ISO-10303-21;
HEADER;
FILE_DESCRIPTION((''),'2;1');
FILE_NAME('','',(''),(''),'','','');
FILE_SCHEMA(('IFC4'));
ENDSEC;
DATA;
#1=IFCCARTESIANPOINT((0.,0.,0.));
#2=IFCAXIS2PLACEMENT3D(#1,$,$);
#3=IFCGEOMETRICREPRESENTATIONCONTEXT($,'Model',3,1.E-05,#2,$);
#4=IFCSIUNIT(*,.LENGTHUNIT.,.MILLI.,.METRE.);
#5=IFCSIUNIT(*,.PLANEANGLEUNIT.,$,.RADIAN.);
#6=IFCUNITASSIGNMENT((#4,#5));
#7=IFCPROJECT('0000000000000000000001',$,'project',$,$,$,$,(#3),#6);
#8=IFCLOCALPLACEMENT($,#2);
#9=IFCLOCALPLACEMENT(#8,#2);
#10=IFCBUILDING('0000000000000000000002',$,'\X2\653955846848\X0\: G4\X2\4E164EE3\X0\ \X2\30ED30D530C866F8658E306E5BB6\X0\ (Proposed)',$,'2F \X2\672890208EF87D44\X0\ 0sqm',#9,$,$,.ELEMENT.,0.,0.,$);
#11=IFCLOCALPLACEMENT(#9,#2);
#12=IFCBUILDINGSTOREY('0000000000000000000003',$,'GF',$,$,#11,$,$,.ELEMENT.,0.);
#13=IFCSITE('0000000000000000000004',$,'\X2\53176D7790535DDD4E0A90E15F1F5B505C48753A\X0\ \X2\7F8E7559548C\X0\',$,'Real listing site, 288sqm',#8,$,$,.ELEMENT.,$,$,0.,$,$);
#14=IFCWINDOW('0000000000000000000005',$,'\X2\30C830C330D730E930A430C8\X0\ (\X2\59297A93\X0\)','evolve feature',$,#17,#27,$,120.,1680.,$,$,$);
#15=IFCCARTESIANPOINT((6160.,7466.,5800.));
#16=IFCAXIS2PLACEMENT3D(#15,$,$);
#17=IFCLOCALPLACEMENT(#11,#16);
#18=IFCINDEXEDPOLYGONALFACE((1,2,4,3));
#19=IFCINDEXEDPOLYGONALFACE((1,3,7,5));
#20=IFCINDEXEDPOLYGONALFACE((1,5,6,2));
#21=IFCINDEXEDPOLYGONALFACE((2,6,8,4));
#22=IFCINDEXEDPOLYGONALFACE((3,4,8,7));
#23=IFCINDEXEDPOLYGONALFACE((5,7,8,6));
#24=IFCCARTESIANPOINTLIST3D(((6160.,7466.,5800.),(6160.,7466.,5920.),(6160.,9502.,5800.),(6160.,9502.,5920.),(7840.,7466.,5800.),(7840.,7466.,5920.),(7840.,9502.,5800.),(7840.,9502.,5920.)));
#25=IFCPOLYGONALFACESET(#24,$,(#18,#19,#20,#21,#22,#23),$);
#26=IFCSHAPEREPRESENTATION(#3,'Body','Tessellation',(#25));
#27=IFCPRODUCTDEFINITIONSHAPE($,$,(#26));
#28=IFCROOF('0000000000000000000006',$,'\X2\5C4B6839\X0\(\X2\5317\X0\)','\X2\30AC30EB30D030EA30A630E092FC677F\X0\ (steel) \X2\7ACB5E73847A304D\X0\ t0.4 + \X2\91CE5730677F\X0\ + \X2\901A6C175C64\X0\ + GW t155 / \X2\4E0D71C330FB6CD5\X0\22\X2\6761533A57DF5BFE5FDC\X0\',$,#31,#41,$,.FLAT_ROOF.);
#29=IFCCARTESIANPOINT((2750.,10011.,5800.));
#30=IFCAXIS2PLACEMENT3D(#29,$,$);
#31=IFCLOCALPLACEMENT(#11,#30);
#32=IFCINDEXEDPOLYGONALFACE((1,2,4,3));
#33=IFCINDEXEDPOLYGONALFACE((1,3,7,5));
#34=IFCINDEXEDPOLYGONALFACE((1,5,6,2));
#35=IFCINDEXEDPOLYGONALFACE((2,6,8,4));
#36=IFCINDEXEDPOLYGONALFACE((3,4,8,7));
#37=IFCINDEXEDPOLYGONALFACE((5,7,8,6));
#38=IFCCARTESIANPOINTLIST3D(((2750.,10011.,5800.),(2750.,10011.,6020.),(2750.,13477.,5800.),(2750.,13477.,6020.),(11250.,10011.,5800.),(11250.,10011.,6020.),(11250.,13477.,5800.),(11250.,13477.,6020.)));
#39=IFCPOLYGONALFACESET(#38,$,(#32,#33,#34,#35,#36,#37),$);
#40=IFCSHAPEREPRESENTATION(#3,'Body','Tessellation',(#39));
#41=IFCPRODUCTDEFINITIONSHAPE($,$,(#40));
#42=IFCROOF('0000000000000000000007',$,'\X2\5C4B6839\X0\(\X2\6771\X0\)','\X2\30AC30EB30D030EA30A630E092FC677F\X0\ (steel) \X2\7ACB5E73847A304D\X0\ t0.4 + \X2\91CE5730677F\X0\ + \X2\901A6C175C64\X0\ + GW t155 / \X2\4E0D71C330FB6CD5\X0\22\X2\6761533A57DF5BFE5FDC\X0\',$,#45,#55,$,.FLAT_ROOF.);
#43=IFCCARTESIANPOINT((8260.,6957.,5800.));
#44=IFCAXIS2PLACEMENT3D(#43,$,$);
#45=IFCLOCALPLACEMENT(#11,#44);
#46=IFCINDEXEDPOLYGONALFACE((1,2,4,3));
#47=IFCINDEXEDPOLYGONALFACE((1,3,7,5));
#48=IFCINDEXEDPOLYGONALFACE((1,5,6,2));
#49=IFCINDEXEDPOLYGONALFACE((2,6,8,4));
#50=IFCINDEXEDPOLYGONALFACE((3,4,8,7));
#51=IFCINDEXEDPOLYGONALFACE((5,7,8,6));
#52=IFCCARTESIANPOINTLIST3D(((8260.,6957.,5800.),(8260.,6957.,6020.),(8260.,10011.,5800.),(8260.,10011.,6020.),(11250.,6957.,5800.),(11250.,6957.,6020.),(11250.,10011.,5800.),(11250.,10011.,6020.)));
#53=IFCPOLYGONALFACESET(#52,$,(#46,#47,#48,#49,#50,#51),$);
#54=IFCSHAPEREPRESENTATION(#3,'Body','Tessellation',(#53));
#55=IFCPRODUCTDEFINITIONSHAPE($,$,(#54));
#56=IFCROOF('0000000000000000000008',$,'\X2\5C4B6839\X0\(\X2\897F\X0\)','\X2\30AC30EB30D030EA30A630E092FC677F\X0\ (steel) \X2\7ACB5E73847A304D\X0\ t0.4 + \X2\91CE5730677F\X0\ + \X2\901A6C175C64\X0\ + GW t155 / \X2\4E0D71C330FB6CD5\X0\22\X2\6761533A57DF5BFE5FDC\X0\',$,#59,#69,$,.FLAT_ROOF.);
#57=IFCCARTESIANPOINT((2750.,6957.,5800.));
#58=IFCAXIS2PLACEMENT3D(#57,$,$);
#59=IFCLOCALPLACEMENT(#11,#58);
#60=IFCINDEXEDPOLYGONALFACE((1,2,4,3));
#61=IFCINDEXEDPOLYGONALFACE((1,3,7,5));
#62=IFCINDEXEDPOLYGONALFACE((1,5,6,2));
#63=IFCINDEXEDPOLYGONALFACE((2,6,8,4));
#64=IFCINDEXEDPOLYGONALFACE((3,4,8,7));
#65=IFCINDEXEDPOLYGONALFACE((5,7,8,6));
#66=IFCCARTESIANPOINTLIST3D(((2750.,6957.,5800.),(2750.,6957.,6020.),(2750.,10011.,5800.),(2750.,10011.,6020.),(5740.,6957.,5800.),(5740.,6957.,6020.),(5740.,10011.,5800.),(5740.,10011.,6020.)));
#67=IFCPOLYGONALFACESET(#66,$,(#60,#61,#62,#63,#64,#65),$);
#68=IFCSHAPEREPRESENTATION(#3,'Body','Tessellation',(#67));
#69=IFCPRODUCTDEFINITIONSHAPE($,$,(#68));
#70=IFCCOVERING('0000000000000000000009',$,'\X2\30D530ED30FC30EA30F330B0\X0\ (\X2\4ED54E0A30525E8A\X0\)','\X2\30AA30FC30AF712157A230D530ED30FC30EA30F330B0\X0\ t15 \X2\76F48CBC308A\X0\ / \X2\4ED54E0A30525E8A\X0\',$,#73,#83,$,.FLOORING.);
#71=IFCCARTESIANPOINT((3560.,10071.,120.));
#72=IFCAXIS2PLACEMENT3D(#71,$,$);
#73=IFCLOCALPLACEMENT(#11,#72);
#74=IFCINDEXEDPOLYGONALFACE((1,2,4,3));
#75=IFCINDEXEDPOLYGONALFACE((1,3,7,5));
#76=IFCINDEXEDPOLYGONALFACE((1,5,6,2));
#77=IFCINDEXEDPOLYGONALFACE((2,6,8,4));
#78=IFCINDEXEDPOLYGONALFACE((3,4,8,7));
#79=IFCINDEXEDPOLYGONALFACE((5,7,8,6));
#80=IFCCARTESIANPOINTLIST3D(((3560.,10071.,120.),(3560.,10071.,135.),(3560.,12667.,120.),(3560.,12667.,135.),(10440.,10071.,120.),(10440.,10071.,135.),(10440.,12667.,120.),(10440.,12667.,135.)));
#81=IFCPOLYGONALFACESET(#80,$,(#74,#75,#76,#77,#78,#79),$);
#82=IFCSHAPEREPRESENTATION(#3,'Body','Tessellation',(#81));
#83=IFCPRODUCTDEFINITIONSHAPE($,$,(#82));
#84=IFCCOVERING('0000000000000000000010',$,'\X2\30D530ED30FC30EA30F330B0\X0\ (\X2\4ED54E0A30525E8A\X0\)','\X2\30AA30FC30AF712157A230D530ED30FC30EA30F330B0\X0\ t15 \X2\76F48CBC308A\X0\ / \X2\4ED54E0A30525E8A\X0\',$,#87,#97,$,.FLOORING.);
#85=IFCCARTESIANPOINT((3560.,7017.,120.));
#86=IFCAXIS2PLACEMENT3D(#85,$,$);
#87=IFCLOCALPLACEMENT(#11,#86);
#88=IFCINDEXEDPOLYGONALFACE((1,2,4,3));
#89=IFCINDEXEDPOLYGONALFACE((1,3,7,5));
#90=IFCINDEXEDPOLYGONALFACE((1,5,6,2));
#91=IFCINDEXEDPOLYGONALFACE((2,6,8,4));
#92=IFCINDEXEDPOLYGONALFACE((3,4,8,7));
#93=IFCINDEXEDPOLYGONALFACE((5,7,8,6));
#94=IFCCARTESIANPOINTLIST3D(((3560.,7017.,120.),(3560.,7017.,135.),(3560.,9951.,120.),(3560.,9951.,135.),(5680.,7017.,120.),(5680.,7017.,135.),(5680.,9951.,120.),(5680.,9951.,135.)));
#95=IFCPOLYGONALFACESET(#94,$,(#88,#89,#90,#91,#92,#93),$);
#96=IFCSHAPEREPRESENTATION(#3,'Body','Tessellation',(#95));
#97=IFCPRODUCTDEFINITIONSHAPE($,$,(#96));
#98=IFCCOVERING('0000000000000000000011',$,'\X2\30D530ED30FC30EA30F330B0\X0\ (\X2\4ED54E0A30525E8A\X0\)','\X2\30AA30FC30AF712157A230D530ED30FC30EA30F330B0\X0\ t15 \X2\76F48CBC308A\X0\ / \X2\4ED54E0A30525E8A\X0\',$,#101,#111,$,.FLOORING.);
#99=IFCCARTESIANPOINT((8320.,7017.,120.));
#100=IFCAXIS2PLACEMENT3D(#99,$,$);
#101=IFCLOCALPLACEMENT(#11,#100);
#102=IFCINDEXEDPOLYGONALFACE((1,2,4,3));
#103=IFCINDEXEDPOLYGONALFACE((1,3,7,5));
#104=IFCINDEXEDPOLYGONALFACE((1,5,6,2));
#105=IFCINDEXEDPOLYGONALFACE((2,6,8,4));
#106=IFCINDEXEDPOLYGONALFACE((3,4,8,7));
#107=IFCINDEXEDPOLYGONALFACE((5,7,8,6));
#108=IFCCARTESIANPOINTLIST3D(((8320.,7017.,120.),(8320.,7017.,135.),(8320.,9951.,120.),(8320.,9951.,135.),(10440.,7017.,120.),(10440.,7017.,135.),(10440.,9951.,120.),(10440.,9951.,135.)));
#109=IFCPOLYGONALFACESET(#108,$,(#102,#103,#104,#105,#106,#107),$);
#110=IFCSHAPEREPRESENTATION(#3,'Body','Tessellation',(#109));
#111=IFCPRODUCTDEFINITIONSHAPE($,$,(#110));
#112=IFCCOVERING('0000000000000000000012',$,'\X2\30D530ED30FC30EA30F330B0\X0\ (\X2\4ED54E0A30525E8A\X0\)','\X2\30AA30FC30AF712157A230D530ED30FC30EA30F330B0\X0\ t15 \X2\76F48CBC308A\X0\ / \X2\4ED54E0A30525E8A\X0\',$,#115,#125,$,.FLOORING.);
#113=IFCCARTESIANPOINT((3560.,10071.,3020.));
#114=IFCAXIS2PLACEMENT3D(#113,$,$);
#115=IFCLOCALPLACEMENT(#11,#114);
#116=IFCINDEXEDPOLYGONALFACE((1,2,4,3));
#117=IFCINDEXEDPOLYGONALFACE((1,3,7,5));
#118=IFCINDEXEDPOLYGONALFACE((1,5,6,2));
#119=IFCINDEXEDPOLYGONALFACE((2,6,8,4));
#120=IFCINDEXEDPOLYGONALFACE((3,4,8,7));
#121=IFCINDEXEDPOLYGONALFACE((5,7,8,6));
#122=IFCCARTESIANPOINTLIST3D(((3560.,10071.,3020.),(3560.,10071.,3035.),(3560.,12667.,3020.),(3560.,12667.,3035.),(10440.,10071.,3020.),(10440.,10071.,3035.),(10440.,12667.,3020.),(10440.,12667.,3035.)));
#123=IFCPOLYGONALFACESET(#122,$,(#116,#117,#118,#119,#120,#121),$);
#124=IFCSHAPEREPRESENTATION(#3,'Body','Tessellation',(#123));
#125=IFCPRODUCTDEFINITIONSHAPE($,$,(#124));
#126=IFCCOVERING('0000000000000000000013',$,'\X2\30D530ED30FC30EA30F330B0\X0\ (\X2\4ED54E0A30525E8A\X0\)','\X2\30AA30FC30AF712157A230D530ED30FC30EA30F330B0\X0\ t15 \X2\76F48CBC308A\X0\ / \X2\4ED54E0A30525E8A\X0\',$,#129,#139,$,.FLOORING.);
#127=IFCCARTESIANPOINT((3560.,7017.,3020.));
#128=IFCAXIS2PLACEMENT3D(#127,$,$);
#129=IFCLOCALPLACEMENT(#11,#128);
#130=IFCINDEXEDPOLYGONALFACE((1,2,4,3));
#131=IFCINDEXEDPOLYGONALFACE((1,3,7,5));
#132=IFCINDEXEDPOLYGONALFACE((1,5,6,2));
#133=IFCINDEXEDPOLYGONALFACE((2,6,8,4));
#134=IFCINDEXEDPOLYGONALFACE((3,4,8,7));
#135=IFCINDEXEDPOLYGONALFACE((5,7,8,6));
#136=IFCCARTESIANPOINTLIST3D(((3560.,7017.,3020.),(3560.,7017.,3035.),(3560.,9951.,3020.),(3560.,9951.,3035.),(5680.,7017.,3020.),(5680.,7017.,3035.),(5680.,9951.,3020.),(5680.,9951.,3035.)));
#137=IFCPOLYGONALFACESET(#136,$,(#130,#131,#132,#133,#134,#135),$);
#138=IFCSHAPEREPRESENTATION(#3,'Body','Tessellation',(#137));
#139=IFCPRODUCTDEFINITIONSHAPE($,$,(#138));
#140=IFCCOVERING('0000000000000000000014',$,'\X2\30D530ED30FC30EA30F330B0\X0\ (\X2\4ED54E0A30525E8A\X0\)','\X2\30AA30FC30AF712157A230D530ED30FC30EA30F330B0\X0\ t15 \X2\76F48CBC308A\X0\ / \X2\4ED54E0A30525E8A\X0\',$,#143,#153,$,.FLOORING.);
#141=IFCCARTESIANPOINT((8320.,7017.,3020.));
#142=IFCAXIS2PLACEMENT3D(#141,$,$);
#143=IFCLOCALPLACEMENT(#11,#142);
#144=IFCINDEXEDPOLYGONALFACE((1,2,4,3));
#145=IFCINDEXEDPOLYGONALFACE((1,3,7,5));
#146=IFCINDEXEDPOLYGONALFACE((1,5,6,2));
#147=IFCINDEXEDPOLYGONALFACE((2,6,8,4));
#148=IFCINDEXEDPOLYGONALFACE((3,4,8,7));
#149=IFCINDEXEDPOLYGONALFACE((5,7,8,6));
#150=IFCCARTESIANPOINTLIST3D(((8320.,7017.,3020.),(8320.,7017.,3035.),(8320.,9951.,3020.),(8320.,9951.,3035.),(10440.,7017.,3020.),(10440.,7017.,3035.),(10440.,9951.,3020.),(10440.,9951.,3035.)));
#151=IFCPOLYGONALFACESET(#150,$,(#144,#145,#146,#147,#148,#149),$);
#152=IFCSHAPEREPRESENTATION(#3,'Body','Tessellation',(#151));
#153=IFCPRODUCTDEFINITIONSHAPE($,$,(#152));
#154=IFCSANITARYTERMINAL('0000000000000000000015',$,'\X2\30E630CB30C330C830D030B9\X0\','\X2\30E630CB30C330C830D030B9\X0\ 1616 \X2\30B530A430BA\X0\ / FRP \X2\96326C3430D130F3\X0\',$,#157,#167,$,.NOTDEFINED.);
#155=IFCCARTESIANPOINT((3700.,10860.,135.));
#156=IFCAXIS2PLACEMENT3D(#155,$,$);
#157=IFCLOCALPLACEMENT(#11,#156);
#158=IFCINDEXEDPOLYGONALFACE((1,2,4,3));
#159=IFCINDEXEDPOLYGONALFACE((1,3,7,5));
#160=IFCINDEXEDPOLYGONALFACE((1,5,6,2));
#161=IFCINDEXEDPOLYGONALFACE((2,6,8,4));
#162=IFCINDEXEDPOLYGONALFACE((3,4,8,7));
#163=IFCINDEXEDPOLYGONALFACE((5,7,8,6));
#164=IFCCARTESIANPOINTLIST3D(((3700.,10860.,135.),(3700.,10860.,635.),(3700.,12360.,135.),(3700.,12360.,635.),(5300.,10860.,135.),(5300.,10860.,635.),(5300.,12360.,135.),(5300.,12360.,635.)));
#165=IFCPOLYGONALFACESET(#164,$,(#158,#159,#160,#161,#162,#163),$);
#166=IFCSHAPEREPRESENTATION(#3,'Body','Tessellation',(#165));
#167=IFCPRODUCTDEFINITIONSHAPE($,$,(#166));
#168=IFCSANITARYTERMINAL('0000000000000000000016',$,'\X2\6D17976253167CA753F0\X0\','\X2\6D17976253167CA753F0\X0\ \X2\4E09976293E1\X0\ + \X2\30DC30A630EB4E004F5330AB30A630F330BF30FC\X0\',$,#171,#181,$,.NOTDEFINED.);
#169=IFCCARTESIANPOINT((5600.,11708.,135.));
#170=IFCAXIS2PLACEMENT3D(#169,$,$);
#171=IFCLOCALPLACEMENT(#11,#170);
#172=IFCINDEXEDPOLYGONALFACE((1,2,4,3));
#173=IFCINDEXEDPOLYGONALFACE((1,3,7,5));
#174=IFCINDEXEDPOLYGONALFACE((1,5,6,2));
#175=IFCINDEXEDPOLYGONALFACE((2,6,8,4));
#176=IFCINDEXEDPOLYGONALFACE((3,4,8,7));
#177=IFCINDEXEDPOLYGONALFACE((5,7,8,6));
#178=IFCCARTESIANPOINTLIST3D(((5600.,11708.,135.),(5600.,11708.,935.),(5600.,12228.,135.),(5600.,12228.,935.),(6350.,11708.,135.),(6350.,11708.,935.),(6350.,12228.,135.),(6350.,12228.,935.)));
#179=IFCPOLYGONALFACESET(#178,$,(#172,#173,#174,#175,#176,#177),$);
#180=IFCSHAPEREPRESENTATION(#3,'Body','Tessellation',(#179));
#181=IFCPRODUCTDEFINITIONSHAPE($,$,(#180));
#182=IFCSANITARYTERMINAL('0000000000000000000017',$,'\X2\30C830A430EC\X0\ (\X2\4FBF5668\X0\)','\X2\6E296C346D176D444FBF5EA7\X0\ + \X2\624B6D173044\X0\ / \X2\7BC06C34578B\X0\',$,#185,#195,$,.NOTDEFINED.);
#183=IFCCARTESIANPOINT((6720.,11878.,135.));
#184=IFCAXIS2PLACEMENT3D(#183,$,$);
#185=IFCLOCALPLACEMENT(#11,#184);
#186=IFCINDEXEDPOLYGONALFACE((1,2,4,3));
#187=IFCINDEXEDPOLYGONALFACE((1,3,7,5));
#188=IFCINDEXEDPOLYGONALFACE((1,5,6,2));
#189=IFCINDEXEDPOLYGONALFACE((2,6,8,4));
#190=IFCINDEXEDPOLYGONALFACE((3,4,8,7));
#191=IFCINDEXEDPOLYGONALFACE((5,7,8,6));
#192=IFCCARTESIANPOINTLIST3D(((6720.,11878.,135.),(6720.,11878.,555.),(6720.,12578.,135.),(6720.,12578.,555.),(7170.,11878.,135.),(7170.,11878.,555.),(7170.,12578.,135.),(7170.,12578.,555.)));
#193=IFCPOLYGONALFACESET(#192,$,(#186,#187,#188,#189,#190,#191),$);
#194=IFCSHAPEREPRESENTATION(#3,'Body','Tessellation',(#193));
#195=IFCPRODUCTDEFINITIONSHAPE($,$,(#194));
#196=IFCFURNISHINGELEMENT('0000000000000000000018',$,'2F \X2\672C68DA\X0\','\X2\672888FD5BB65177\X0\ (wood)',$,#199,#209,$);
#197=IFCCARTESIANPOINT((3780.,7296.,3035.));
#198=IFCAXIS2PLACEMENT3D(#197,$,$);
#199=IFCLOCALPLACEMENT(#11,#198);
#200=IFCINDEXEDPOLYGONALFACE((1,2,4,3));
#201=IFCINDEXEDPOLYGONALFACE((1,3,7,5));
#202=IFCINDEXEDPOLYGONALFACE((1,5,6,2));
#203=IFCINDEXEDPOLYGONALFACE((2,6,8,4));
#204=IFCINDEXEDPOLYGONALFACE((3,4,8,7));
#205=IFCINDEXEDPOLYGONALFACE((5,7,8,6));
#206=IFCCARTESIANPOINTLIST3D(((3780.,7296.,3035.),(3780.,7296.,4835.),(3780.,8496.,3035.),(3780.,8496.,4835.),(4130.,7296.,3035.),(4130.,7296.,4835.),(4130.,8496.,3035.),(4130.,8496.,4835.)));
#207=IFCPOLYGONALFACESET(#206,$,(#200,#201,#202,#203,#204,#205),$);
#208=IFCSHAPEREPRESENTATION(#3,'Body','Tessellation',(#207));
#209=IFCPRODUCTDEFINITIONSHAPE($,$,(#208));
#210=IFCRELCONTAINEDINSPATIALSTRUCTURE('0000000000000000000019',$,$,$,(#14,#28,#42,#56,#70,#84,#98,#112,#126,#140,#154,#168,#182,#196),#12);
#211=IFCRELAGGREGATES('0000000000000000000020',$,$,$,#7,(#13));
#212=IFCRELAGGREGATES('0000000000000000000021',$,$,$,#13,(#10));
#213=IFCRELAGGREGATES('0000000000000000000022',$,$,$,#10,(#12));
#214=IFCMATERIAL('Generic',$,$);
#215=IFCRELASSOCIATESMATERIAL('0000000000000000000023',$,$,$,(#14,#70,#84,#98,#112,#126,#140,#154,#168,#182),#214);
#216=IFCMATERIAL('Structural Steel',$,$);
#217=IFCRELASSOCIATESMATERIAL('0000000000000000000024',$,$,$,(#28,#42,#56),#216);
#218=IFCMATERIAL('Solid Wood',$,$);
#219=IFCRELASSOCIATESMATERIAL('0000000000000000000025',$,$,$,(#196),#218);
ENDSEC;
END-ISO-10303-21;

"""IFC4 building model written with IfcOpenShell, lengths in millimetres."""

from ifc_helpers import new_model, si_unit, frame, frame_2d, origin, place, context, project, spatial, rectangle, extrude, material, element, save


model = new_model("IFC4")

# Units and contexts
model_context = context("Model", 3, precision=1e-05, world=origin())
ifc_project = project(units=[si_unit("LENGTHUNIT", "METRE", prefix="MILLI"), si_unit("PLANEANGLEUNIT", "RADIAN")], contexts=[model_context])

# Site, building, storey
site_placement = place(None, origin())
site = spatial("IfcSite", under=ifc_project, at=site_placement, Name="北海道川上郡弟子屈町 美留和", ObjectType="Real listing site, 288sqm", CompositionType="ELEMENT", RefElevation=0.0)
building_placement = place(site_placement, origin())
building = spatial("IfcBuilding", under=site, at=building_placement, Name="改善案: G4世代 ロフト書斎の家 (Proposed)", ObjectType="2F 木造軸組 0sqm", CompositionType="ELEMENT", ElevationOfRefHeight=0.0, ElevationOfTerrain=0.0)
storey_placement = place(building_placement, origin())
storey = spatial("IfcBuildingStorey", under=building, at=storey_placement, Name="GF", CompositionType="ELEMENT", Elevation=0.0)

# Shared definitions
ifc_material_1 = material(Name="Solid Wood")

# Window
ifc_material_2 = material(Name="Generic")
window_1_placement = place(storey_placement, frame((6160.0, 7466.0, 5800.0)))
element("IfcWindow", 1, at=window_1_placement, inside=storey, material=ifc_material_2, Name="トップライト (天窓)", Description="evolve feature", OverallHeight=120.0, OverallWidth=1680.0, context=model_context, shape_type="SweptSolid", body=[
    extrude(rectangle(XDim=1680.0, YDim=2036.0, at=frame_2d((840.0, 1018.0))), frame((6160.0, 7466.0, 5800.0)), (0.0, 0.0, 1.0), 120.0),
])

# Roofs
ifc_material_3 = material(Name="Structural Steel")
roof_1_placement = place(storey_placement, frame((2750.0, 10011.0, 5800.0)))
element("IfcRoof", 2, at=roof_1_placement, inside=storey, material=ifc_material_3, Name="屋根(北)", Description="ガルバリウム鋼板 (steel) 立平葺き t0.4 + 野地板 + 通気層 + GW t155 / 不燃・法22条区域対応", PredefinedType="FLAT_ROOF", context=model_context, shape_type="SweptSolid", body=[
    extrude(rectangle(XDim=8500.0, YDim=3466.0, at=frame_2d((4250.0, 1733.0))), frame((2750.0, 10011.0, 5800.0)), (0.0, 0.0, 1.0), 220.0),
])
roof_2_placement = place(storey_placement, frame((8260.0, 6957.0, 5800.0)))
element("IfcRoof", 3, at=roof_2_placement, inside=storey, material=ifc_material_3, Name="屋根(東)", Description="ガルバリウム鋼板 (steel) 立平葺き t0.4 + 野地板 + 通気層 + GW t155 / 不燃・法22条区域対応", PredefinedType="FLAT_ROOF", context=model_context, shape_type="SweptSolid", body=[
    extrude(rectangle(XDim=2990.0, YDim=3054.0, at=frame_2d((1495.0, 1527.0))), frame((8260.0, 6957.0, 5800.0)), (0.0, 0.0, 1.0), 220.0),
])
roof_3_placement = place(storey_placement, frame((2750.0, 6957.0, 5800.0)))
element("IfcRoof", 4, at=roof_3_placement, inside=storey, material=ifc_material_3, Name="屋根(西)", Description="ガルバリウム鋼板 (steel) 立平葺き t0.4 + 野地板 + 通気層 + GW t155 / 不燃・法22条区域対応", PredefinedType="FLAT_ROOF", context=model_context, shape_type="SweptSolid", body=[
    extrude(rectangle(XDim=2990.0, YDim=3054.0, at=frame_2d((1495.0, 1527.0))), frame((2750.0, 6957.0, 5800.0)), (0.0, 0.0, 1.0), 220.0),
])

# Coverings
covering_1_placement = place(storey_placement, frame((3560.0, 10071.0, 120.0)))
element("IfcCovering", 5, at=covering_1_placement, inside=storey, material=ifc_material_2, Name="フローリング (仕上げ床)", Description="オーク無垢フローリング t15 直貼り / 仕上げ床", PredefinedType="FLOORING", context=model_context, shape_type="SweptSolid", body=[
    extrude(rectangle(XDim=6880.0, YDim=2596.0, at=frame_2d((3440.0, 1298.0))), frame((3560.0, 10071.0, 120.0)), (0.0, 0.0, 1.0), 15.0),
])
covering_2_placement = place(storey_placement, frame((3560.0, 7017.0, 120.0)))
element("IfcCovering", 6, at=covering_2_placement, inside=storey, material=ifc_material_2, Name="フローリング (仕上げ床)", Description="オーク無垢フローリング t15 直貼り / 仕上げ床", PredefinedType="FLOORING", context=model_context, shape_type="SweptSolid", body=[
    extrude(rectangle(XDim=2120.0, YDim=2934.0, at=frame_2d((1060.0, 1467.0))), frame((3560.0, 7017.0, 120.0)), (0.0, 0.0, 1.0), 15.0),
])
covering_3_placement = place(storey_placement, frame((8320.0, 7017.0, 120.0)))
element("IfcCovering", 7, at=covering_3_placement, inside=storey, material=ifc_material_2, Name="フローリング (仕上げ床)", Description="オーク無垢フローリング t15 直貼り / 仕上げ床", PredefinedType="FLOORING", context=model_context, shape_type="SweptSolid", body=[
    extrude(rectangle(XDim=2120.0, YDim=2934.0, at=frame_2d((1060.0, 1467.0))), frame((8320.0, 7017.0, 120.0)), (0.0, 0.0, 1.0), 15.0),
])
covering_4_placement = place(storey_placement, frame((3560.0, 10071.0, 3020.0)))
element("IfcCovering", 8, at=covering_4_placement, inside=storey, material=ifc_material_2, Name="フローリング (仕上げ床)", Description="オーク無垢フローリング t15 直貼り / 仕上げ床", PredefinedType="FLOORING", context=model_context, shape_type="SweptSolid", body=[
    extrude(rectangle(XDim=6880.0, YDim=2596.0, at=frame_2d((3440.0, 1298.0))), frame((3560.0, 10071.0, 3020.0)), (0.0, 0.0, 1.0), 15.0),
])
covering_5_placement = place(storey_placement, frame((3560.0, 7017.0, 3020.0)))
element("IfcCovering", 9, at=covering_5_placement, inside=storey, material=ifc_material_2, Name="フローリング (仕上げ床)", Description="オーク無垢フローリング t15 直貼り / 仕上げ床", PredefinedType="FLOORING", context=model_context, shape_type="SweptSolid", body=[
    extrude(rectangle(XDim=2120.0, YDim=2934.0, at=frame_2d((1060.0, 1467.0))), frame((3560.0, 7017.0, 3020.0)), (0.0, 0.0, 1.0), 15.0),
])
covering_6_placement = place(storey_placement, frame((8320.0, 7017.0, 3020.0)))
element("IfcCovering", 10, at=covering_6_placement, inside=storey, material=ifc_material_2, Name="フローリング (仕上げ床)", Description="オーク無垢フローリング t15 直貼り / 仕上げ床", PredefinedType="FLOORING", context=model_context, shape_type="SweptSolid", body=[
    extrude(rectangle(XDim=2120.0, YDim=2934.0, at=frame_2d((1060.0, 1467.0))), frame((8320.0, 7017.0, 3020.0)), (0.0, 0.0, 1.0), 15.0),
])

# Sanitary terminals
sanitary_terminal_1_placement = place(storey_placement, frame((3700.0, 10860.0, 135.0)))
element("IfcSanitaryTerminal", 11, at=sanitary_terminal_1_placement, inside=storey, material=ifc_material_2, Name="ユニットバス", Description="ユニットバス 1616 サイズ / FRP 防水パン", PredefinedType="NOTDEFINED", context=model_context, shape_type="SweptSolid", body=[
    extrude(rectangle(XDim=1600.0, YDim=1500.0, at=frame_2d((800.0, 750.0))), frame((3700.0, 10860.0, 135.0)), (0.0, 0.0, 1.0), 500.0),
])
sanitary_terminal_2_placement = place(storey_placement, frame((5600.0, 11708.0, 135.0)))
element("IfcSanitaryTerminal", 12, at=sanitary_terminal_2_placement, inside=storey, material=ifc_material_2, Name="洗面化粧台", Description="洗面化粧台 三面鏡 + ボウル一体カウンター", PredefinedType="NOTDEFINED", context=model_context, shape_type="SweptSolid", body=[
    extrude(rectangle(XDim=750.0, YDim=520.0, at=frame_2d((375.0, 260.0))), frame((5600.0, 11708.0, 135.0)), (0.0, 0.0, 1.0), 800.0),
])
sanitary_terminal_3_placement = place(storey_placement, frame((6720.0, 11878.0, 135.0)))
element("IfcSanitaryTerminal", 13, at=sanitary_terminal_3_placement, inside=storey, material=ifc_material_2, Name="トイレ (便器)", Description="温水洗浄便座 + 手洗い / 節水型", PredefinedType="NOTDEFINED", context=model_context, shape_type="SweptSolid", body=[
    extrude(rectangle(XDim=450.0, YDim=700.0, at=frame_2d((225.0, 350.0))), frame((6720.0, 11878.0, 135.0)), (0.0, 0.0, 1.0), 420.0),
])

# Furnishing element
furnishing_placement = place(storey_placement, frame((3780.0, 7296.0, 3035.0)))
element("IfcFurnishingElement", 14, at=furnishing_placement, inside=storey, material=ifc_material_1, Name="2F 本棚", Description="木製家具 (wood)", context=model_context, shape_type="SweptSolid", body=[
    extrude(rectangle(XDim=350.0, YDim=1200.0, at=frame_2d((175.0, 600.0))), frame((3780.0, 7296.0, 3035.0)), (0.0, 0.0, 1.0), 1800.0),
])

save(model, "model.ifc")
